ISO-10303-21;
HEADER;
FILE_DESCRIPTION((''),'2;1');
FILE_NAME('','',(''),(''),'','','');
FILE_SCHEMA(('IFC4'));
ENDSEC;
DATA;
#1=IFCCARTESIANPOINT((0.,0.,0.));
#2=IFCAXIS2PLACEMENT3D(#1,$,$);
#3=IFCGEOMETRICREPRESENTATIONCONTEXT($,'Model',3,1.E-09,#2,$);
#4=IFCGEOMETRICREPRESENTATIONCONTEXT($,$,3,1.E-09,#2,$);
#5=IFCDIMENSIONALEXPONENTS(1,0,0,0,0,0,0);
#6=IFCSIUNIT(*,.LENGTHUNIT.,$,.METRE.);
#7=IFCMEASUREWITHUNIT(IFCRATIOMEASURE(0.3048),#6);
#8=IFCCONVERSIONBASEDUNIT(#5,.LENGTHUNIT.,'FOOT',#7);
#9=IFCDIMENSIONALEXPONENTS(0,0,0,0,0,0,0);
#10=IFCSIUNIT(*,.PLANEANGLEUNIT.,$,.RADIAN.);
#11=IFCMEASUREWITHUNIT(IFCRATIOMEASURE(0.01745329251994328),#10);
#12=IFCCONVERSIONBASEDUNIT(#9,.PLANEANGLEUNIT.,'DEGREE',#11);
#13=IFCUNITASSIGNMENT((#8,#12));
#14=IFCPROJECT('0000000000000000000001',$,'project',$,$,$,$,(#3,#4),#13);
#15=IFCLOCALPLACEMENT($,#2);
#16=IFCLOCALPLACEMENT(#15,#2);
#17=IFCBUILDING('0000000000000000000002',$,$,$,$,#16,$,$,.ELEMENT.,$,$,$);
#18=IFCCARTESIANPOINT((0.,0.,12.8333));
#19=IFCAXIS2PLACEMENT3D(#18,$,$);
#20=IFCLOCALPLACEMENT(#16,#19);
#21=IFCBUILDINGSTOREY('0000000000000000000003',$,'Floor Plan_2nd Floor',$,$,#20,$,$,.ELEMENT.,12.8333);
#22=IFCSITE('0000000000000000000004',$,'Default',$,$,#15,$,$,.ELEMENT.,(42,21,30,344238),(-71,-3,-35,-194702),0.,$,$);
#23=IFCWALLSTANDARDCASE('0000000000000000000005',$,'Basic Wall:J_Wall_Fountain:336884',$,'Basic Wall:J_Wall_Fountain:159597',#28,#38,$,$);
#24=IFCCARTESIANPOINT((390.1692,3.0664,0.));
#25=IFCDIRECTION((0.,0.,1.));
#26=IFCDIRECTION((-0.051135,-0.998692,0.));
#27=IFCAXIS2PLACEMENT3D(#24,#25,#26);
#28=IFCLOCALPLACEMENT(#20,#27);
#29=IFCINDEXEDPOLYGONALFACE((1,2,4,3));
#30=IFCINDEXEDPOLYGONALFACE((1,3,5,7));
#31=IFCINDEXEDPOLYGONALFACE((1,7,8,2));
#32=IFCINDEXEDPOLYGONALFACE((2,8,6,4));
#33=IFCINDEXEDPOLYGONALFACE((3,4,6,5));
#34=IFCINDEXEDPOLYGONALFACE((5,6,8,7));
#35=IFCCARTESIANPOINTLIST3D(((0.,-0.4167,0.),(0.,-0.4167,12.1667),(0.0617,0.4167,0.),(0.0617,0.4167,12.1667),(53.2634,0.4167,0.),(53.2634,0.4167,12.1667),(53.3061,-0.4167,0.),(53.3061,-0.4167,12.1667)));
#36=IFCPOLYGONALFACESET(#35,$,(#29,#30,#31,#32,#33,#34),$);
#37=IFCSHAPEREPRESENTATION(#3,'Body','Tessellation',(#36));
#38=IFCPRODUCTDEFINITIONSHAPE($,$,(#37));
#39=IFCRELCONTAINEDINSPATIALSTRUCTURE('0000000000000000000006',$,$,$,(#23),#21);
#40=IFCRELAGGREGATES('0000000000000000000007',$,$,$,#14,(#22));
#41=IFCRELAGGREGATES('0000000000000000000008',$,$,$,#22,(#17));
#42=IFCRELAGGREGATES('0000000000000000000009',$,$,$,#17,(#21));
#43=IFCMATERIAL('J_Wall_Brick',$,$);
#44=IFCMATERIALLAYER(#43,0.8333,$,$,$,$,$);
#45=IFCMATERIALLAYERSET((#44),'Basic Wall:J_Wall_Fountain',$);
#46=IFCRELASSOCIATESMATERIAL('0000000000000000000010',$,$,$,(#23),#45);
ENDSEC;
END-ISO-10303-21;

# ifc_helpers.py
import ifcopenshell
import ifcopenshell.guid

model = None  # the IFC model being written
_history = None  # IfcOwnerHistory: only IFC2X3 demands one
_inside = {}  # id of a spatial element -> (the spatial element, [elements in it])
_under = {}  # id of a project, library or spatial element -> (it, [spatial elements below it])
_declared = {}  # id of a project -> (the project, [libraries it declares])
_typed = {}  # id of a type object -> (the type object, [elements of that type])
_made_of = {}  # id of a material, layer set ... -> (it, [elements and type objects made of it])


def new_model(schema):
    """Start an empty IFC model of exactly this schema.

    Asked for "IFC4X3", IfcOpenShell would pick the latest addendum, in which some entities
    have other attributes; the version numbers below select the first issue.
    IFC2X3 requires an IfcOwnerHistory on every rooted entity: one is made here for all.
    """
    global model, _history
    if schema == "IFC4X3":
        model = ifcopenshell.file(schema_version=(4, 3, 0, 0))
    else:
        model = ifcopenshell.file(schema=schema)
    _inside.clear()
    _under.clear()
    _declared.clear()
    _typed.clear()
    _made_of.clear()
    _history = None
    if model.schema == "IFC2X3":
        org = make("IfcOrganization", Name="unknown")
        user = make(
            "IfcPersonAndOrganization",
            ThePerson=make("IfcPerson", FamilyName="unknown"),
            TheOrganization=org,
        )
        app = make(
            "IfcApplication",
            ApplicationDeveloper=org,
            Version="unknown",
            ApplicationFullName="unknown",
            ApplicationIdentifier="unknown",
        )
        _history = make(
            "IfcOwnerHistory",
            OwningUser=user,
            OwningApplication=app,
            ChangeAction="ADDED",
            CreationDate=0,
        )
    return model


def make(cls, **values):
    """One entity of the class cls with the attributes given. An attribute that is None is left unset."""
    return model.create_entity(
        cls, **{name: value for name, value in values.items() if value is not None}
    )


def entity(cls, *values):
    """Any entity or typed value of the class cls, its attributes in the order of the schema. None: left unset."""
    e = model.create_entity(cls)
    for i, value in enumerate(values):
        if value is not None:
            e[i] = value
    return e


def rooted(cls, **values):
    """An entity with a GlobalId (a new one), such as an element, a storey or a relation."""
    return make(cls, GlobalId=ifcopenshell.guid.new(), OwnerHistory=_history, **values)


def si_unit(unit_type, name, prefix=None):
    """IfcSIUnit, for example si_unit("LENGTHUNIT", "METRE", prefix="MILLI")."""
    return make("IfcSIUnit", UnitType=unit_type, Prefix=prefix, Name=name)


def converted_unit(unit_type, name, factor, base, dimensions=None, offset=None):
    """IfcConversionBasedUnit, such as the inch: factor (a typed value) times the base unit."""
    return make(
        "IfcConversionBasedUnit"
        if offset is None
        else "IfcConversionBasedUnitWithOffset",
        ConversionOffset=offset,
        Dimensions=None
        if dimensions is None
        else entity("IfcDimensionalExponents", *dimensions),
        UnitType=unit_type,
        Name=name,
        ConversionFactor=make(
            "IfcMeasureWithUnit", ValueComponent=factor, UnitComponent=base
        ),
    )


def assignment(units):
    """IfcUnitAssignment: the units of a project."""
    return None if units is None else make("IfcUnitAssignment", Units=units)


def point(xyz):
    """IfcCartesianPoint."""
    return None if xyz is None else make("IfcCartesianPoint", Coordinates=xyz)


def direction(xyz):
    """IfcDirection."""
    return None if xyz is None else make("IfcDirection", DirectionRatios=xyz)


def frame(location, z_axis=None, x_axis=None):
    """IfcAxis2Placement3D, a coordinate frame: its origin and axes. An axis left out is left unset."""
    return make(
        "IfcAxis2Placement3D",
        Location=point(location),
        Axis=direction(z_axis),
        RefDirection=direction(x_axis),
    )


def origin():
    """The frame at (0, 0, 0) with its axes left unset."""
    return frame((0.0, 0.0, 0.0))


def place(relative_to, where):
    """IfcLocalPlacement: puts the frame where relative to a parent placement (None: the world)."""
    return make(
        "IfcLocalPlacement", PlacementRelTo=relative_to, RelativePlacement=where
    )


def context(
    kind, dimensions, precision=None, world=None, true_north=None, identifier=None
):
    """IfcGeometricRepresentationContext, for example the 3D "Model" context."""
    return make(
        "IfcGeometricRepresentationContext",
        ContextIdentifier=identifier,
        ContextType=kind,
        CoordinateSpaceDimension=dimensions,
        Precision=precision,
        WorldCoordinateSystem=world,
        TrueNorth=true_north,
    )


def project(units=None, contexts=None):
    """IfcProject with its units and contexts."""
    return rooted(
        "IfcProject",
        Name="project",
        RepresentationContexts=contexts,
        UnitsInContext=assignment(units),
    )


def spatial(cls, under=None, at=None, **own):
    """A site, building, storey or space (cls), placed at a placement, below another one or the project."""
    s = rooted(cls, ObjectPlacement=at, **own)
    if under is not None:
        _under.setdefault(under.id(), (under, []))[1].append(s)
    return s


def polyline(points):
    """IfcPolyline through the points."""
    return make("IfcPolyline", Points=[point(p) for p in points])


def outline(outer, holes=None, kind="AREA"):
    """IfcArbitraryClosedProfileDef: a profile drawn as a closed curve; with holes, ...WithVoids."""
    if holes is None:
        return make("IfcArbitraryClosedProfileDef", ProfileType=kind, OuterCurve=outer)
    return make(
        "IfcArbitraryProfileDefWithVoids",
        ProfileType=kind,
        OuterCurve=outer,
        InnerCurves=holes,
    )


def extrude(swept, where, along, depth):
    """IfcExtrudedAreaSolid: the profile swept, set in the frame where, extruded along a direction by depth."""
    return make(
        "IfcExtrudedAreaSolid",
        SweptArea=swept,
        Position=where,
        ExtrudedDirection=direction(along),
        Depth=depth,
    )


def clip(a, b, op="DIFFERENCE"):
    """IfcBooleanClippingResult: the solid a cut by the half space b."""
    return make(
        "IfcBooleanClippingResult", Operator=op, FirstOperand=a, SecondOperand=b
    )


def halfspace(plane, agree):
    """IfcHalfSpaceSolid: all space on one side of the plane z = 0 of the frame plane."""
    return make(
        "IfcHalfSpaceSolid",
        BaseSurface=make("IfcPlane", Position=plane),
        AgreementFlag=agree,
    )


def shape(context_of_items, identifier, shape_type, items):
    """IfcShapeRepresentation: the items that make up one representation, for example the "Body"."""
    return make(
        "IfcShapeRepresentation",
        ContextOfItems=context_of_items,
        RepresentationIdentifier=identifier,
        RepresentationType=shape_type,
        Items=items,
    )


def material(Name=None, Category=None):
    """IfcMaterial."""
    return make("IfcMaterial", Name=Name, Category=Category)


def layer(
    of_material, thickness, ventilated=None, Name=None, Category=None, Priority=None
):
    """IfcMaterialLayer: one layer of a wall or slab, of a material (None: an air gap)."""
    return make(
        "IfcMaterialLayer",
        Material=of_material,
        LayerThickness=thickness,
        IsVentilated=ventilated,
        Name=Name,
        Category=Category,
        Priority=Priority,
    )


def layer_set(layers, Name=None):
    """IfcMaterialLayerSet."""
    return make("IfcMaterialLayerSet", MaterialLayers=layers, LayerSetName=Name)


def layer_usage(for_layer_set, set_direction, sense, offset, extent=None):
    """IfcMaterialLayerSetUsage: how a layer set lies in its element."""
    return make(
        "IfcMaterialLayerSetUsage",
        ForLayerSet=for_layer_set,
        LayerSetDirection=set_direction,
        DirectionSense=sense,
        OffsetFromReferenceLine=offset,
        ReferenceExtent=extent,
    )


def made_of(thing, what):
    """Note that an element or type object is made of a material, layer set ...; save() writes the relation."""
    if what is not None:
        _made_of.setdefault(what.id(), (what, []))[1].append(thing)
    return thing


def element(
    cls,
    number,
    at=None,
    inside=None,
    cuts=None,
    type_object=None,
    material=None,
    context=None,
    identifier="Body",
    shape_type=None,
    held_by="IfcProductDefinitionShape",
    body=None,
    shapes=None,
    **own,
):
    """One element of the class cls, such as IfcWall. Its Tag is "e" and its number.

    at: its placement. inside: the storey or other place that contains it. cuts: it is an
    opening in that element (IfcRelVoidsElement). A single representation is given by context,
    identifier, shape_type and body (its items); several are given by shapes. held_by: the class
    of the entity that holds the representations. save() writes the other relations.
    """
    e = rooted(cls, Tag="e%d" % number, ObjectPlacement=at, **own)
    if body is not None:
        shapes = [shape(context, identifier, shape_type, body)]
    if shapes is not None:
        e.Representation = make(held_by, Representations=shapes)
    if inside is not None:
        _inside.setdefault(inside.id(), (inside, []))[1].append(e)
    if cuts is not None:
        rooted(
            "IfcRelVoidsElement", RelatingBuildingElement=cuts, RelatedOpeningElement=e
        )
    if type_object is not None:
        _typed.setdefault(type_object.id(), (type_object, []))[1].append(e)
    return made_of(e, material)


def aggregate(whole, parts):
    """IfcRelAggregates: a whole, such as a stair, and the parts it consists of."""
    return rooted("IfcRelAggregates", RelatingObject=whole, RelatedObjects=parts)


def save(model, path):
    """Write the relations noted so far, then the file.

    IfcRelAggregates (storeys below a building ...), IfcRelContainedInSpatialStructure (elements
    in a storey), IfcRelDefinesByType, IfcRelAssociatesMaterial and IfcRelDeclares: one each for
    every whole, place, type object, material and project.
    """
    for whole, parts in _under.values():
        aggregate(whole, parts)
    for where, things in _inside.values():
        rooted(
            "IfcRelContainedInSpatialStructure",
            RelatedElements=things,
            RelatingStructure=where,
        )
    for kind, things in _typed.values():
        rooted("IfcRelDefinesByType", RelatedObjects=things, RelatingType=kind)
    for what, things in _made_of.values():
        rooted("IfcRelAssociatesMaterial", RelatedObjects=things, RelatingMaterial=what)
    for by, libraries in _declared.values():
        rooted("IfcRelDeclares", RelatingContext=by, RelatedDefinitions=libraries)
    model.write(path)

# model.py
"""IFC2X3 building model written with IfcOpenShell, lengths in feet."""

from ifc_helpers import new_model, entity, si_unit, converted_unit, frame, origin, place, context, project, spatial, polyline, outline, extrude, clip, halfspace, material, layer, layer_set, layer_usage, element, save


model = new_model("IFC2X3")

# Units and contexts
model_context = context("Model", 3, precision=1e-09, world=origin())
context_of_model = context(None, 3, precision=1e-09, world=origin())
ifc_project = project(units=[converted_unit("LENGTHUNIT", "FOOT", entity("IfcRatioMeasure", 0.3048), si_unit("LENGTHUNIT", "METRE"), dimensions=[1, 0, 0, 0, 0, 0, 0]), converted_unit("PLANEANGLEUNIT", "DEGREE", entity("IfcRatioMeasure", 0.01745329251994328), si_unit("PLANEANGLEUNIT", "RADIAN"), dimensions=[0, 0, 0, 0, 0, 0, 0])], contexts=[model_context, context_of_model])

# Site, building, storey
site_placement = place(None, origin())
site = spatial("IfcSite", under=ifc_project, at=site_placement, Name="Default", CompositionType="ELEMENT", RefLatitude=(42, 21, 30, 344238), RefLongitude=(-71, -3, -35, -194702), RefElevation=0.0)
building_placement = place(site_placement, origin())
building = spatial("IfcBuilding", under=site, at=building_placement, CompositionType="ELEMENT")
storey_placement = place(building_placement, frame((0.0, 0.0, 12.8333)))
storey = spatial("IfcBuildingStorey", under=building, at=storey_placement, Name="Floor Plan_2nd Floor", CompositionType="ELEMENT", Elevation=12.8333)

# Shared definitions
ifc_material_1 = material(Name="J_Wall_Brick")

# Wall
ifc_layer_1 = layer(ifc_material_1, 0.8333)
ifc_layer_set_1 = layer_set([ifc_layer_1], Name="Basic Wall:J_Wall_Fountain")
ifc_layer_usage_1 = layer_usage(ifc_layer_set_1, "AXIS2", "NEGATIVE", 0.4167)
wall_1_placement = place(storey_placement, frame((390.1692, 3.0664, 0.0), z_axis=(0.0, 0.0, 1.0), x_axis=(-0.051135, -0.998692, 0.0)))
element("IfcWallStandardCase", 1, at=wall_1_placement, inside=storey, material=ifc_layer_usage_1, Name="Basic Wall:J_Wall_Fountain:336884", ObjectType="Basic Wall:J_Wall_Fountain:159597", context=model_context, shape_type="Clipping", body=[
    clip(extrude(outline(polyline([(53.3061, -0.4167), (53.2634, 0.4167), (0.0617, 0.4167), (0.0, -0.4167), (0.7103, -0.4167), (50.7611, -0.4167), (51.4703, -0.4167), (53.3061, -0.4167)])), origin(), (0.0, 0.0, 1.0), 12.1667), halfspace(frame((0.0, 0.0, -0.5417)), True)),
])

save(model, "model.ifc")
